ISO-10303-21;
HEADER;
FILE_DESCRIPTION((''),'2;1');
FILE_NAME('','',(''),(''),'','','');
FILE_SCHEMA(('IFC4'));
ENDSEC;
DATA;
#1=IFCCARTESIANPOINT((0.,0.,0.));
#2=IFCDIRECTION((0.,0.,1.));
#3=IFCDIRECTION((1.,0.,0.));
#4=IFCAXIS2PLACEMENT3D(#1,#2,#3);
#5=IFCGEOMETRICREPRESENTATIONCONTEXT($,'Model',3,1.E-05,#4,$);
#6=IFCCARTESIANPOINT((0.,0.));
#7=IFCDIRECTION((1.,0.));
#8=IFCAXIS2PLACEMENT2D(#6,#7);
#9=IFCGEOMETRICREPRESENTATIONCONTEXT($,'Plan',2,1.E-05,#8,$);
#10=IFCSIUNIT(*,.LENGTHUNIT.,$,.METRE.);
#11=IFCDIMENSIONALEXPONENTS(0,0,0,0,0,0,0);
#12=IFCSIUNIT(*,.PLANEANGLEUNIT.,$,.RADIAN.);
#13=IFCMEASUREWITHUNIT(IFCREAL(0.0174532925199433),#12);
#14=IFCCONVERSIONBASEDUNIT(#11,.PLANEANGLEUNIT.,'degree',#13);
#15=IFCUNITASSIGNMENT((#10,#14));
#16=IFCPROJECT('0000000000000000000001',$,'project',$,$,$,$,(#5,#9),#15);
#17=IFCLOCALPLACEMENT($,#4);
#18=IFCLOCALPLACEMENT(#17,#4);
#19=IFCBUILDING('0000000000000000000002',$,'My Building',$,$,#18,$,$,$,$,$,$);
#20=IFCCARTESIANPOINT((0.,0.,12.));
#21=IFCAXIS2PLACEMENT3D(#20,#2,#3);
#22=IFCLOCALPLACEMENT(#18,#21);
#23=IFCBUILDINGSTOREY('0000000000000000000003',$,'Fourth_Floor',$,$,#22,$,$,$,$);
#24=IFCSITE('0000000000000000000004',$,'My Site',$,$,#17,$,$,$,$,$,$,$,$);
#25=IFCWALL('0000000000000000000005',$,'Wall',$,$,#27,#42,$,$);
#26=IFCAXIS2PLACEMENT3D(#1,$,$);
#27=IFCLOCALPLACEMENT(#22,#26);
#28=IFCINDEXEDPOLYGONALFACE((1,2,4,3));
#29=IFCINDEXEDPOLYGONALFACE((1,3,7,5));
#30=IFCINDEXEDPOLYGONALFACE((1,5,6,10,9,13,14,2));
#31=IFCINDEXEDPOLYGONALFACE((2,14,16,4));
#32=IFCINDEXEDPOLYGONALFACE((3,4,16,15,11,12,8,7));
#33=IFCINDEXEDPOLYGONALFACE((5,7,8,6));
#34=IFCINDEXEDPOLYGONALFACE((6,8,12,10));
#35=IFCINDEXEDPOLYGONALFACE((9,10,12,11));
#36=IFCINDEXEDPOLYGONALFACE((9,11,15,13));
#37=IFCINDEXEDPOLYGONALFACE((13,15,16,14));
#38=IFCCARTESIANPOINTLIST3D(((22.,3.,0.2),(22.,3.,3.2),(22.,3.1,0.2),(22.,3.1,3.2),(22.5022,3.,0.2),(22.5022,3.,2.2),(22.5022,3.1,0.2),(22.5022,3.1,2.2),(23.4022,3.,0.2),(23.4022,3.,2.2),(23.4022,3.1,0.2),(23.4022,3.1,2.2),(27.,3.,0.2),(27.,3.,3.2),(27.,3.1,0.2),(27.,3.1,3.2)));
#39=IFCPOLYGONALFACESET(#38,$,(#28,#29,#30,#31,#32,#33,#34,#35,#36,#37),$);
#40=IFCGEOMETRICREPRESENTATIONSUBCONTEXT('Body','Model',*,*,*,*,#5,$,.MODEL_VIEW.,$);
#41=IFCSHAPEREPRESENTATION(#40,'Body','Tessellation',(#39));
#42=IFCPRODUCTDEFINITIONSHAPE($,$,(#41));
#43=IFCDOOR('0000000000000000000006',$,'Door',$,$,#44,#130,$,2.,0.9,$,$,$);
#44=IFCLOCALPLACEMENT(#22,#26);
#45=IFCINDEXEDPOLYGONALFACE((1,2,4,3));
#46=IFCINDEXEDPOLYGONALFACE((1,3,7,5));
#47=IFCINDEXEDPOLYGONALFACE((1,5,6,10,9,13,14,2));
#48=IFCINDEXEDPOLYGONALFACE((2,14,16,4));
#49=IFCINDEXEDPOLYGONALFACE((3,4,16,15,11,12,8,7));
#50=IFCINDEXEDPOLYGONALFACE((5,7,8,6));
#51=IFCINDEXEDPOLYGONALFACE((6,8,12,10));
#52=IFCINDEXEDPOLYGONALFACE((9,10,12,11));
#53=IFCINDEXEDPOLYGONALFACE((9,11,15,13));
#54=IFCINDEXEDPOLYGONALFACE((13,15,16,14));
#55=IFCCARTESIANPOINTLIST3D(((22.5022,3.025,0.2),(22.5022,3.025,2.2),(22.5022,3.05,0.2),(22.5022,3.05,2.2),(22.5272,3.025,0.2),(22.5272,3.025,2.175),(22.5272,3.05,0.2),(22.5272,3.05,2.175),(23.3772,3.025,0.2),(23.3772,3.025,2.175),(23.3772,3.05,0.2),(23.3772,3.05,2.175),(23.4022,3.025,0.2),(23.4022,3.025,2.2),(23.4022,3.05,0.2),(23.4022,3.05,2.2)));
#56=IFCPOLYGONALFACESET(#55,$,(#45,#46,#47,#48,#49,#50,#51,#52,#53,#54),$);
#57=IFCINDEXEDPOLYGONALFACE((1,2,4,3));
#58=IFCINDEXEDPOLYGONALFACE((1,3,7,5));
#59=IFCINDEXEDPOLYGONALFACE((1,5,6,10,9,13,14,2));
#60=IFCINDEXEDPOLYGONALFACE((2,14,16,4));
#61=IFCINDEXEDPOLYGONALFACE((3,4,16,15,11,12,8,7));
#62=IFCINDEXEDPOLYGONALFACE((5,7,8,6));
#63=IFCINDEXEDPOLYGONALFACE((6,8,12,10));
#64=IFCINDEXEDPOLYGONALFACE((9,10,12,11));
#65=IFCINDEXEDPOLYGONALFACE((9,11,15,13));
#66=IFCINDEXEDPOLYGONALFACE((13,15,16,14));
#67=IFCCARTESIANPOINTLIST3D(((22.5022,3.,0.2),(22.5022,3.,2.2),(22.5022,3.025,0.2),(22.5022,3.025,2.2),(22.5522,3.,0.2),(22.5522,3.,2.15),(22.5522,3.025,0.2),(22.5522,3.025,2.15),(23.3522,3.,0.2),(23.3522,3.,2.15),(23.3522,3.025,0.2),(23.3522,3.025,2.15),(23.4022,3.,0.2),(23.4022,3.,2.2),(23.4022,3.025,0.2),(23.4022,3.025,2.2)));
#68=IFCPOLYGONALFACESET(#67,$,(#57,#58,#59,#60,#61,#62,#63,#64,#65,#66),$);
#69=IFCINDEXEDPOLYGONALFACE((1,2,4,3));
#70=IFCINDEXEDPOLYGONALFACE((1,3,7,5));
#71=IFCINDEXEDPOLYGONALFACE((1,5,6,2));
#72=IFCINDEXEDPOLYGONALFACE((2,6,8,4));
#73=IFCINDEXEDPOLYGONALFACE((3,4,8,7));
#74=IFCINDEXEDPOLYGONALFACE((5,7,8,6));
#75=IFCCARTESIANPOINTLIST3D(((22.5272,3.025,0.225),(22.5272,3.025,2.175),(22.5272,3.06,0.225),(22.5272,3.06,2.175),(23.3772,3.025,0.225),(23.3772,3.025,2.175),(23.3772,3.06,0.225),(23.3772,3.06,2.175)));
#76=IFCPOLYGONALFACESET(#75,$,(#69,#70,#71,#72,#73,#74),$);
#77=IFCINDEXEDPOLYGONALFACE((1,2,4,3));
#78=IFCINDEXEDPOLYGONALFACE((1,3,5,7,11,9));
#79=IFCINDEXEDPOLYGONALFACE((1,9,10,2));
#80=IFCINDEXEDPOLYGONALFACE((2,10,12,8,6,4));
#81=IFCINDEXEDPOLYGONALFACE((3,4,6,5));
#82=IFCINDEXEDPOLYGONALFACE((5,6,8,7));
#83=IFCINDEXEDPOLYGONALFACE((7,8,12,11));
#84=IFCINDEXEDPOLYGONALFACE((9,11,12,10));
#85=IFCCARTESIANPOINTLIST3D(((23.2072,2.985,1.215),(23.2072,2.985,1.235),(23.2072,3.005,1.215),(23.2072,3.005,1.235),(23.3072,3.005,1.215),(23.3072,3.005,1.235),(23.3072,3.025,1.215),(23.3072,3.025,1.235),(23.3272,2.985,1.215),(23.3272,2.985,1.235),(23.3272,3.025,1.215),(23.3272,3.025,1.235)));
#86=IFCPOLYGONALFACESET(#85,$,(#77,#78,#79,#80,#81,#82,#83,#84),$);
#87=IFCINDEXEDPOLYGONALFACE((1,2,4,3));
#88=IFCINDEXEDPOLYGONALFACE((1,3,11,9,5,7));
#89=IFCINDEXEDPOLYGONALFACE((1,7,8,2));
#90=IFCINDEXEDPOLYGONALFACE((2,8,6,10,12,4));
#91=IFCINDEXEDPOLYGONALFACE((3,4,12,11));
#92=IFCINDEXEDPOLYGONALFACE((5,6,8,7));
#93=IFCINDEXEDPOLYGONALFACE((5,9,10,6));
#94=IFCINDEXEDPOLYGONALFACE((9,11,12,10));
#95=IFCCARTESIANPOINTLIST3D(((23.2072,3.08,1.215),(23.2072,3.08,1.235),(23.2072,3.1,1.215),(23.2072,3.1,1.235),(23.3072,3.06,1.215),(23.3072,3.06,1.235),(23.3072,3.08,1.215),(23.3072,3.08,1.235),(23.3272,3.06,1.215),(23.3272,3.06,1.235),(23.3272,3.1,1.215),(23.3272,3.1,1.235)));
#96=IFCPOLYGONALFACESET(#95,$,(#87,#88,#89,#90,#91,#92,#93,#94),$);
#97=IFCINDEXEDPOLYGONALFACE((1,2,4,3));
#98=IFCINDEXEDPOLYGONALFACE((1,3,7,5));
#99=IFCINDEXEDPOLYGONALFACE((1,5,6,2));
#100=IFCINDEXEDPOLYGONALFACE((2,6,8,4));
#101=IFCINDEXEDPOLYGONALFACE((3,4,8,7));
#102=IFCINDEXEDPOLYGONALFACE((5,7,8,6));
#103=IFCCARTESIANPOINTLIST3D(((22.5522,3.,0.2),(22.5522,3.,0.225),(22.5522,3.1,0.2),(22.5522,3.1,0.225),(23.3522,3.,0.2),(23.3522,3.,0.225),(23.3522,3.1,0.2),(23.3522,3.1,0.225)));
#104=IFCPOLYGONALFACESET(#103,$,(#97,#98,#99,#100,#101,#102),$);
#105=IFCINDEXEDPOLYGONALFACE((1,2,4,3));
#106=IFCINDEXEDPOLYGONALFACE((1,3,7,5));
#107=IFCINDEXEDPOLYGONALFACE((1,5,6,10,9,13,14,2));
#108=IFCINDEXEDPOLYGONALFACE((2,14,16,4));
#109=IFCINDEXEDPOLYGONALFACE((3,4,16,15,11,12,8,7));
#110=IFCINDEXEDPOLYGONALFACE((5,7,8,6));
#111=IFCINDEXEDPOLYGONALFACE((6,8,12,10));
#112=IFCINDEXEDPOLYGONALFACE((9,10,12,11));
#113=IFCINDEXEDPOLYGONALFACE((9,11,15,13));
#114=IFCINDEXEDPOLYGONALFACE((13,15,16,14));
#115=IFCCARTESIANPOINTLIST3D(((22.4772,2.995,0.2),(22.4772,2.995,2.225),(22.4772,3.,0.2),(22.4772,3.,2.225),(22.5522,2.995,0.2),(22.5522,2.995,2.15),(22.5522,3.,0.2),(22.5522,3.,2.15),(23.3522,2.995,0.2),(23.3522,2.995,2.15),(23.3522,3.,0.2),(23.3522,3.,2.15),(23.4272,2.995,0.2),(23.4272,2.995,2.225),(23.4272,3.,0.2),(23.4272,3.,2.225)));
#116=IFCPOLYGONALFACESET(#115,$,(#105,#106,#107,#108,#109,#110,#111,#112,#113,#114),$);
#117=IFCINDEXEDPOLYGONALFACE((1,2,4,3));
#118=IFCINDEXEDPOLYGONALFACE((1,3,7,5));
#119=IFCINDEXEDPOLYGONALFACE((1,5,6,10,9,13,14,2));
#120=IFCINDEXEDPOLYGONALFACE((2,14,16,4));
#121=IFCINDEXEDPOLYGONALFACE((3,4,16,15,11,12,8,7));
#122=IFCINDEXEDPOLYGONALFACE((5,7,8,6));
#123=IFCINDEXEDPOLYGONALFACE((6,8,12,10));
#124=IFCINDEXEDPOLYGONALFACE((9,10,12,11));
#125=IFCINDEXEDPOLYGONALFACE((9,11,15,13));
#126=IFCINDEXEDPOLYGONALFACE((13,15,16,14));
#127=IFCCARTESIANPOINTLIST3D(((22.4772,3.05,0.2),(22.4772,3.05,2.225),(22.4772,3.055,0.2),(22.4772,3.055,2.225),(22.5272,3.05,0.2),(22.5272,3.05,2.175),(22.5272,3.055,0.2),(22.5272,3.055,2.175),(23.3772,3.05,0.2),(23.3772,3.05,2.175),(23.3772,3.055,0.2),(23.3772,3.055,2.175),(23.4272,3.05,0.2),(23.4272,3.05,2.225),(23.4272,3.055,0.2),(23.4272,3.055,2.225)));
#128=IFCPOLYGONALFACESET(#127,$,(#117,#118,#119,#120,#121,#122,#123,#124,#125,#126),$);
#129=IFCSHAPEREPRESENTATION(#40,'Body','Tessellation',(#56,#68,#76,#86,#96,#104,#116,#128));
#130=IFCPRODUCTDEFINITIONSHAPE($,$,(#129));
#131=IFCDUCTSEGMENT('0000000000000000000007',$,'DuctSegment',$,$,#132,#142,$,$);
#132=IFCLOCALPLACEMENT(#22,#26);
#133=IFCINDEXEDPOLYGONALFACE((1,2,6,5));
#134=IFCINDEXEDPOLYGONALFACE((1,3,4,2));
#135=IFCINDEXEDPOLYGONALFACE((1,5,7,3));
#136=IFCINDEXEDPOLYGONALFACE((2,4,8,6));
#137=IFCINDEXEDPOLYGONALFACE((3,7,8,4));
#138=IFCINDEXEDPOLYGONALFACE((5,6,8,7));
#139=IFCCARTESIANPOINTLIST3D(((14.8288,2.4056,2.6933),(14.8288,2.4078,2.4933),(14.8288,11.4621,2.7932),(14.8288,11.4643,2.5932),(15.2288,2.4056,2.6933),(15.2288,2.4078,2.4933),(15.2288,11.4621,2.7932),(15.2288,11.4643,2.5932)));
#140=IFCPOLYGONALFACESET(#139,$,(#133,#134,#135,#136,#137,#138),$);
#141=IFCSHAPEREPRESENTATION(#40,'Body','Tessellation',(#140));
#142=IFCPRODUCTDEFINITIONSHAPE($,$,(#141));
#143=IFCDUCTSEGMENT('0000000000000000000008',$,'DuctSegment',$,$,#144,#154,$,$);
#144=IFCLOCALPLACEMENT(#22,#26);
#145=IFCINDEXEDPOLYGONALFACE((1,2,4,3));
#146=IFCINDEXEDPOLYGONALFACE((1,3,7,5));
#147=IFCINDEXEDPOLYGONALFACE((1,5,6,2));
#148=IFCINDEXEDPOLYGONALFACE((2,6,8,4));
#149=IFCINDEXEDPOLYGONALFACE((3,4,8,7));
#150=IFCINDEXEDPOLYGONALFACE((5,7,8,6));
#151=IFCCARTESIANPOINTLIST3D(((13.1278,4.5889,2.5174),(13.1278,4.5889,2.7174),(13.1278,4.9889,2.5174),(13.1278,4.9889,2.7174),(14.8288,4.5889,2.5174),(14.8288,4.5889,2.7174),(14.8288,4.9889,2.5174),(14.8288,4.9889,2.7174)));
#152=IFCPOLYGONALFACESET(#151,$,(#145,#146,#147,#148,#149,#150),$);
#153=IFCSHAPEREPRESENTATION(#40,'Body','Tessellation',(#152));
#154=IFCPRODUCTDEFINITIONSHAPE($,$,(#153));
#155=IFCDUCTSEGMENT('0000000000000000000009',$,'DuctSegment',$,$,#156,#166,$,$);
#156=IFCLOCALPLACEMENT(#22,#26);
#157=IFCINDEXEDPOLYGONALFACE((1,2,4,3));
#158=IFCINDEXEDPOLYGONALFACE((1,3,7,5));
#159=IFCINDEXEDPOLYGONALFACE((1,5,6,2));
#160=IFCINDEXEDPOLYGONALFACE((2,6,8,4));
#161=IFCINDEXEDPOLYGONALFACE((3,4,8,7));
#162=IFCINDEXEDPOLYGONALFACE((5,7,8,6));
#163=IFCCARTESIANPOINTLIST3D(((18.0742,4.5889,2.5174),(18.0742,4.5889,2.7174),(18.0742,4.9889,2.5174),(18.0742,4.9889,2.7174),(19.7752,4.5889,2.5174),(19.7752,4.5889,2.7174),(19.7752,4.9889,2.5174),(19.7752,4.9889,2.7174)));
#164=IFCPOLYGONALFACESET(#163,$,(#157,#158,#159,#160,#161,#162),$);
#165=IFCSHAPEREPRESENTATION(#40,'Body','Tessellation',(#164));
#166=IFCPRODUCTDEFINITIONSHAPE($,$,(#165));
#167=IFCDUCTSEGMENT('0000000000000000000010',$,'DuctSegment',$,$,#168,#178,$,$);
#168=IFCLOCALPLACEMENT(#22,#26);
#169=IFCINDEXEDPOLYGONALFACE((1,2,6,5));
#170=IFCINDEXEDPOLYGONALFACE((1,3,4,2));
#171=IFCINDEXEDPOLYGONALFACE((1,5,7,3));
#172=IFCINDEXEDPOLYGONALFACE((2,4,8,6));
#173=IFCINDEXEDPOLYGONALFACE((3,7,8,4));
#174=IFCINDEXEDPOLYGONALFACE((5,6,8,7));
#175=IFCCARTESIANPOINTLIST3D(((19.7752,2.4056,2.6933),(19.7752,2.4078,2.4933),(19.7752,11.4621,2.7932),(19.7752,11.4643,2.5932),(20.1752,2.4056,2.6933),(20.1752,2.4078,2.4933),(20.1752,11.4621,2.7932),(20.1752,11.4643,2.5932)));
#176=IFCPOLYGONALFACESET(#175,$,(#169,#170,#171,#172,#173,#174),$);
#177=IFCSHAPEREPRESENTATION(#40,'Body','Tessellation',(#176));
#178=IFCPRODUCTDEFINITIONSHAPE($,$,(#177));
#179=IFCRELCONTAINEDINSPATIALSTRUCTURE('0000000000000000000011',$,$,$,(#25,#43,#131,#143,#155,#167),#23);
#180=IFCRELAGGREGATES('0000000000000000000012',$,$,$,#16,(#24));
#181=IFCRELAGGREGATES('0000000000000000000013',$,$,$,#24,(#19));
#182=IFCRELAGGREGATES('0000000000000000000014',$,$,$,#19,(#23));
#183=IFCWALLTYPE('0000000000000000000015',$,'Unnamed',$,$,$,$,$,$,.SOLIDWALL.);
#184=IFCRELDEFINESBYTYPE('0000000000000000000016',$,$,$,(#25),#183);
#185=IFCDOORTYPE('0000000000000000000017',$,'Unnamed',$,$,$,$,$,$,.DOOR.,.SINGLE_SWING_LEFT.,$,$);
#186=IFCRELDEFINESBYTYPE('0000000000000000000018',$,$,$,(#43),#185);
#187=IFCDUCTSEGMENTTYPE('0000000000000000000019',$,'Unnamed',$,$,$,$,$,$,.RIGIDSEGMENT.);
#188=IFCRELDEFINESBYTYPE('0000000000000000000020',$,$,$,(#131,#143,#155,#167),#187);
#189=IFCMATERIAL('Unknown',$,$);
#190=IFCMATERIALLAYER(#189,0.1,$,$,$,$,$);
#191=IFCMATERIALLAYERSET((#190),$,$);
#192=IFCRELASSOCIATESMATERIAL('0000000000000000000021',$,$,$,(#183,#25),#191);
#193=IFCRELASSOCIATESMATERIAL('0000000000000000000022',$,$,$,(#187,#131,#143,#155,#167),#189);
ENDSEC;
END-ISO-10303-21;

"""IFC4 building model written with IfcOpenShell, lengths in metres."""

from ifc_helpers import new_model, entity, si_unit, converted_unit, frame, origin_with_axes, origin_2d_with_axis, place, context, subcontext, project, spatial, line, indexed_curve, rectangle, outline, extrude, shape, source, transform, mapped, material, layer, layer_set, layer_usage, material_profile, profile_set, profile_usage, type_object, type_shapes, element, fill, save


model = new_model("IFC4")

# Units and contexts
model_context = context("Model", 3, precision=1e-05, world=origin_with_axes())
plan_context = context("Plan", 2, precision=1e-05, world=origin_2d_with_axis())
body_context_1 = subcontext(model_context, "Body", "Model", "MODEL_VIEW")
body_context_2 = subcontext(plan_context, "Body", "Plan", "PLAN_VIEW")
ifc_project = project(units=[si_unit("LENGTHUNIT", "METRE"), converted_unit("PLANEANGLEUNIT", "degree", entity("IfcReal", 0.0174532925199433), si_unit("PLANEANGLEUNIT", "RADIAN"), dimensions=[0, 0, 0, 0, 0, 0, 0])], contexts=[model_context, plan_context])

# Site, building, storey
site_placement = place(None, origin_with_axes())
site = spatial("IfcSite", under=ifc_project, at=site_placement, Name="My Site")
building_placement = place(site_placement, origin_with_axes())
building = spatial("IfcBuilding", under=site, at=building_placement, Name="My Building")
storey_placement = place(building_placement, frame((0.0, 0.0, 12.0), z_axis=(0.0, 0.0, 1.0), x_axis=(1.0, 0.0, 0.0)))
storey = spatial("IfcBuildingStorey", under=building, at=storey_placement, Name="Fourth_Floor")

# Wall, opening, door
ifc_material = material(Name="Unknown")
ifc_layer = layer(ifc_material, 0.1)
ifc_layer_set = layer_set([ifc_layer])
wall_type = type_object("IfcWallType", Name="Unnamed", PredefinedType="SOLIDWALL", material=ifc_layer_set)
shared_shape_1 = source(origin_with_axes(), body_context_1, "Body", "SweptSolid", [
    extrude(outline(indexed_curve([(0.0, 0.0), (0.9, 0.0), (0.9, 2.0), (0.0, 2.0)], segments=[line(1, 2, 3, 4, 1)])), frame((0.0, -0.6, 0.0), z_axis=(0.0, -1.0, 0.0), x_axis=(1.0, 0.0, 0.0)), (0.0, 0.0, -1.0), 1.2),
])
door_type = type_object("IfcDoorType", Name="Unnamed", OperationType="SINGLE_SWING_LEFT", PredefinedType="DOOR")
shared_shape_2 = source(origin_with_axes(), body_context_1, "Body", "SweptSolid", [
    extrude(outline(indexed_curve([(0.0, 0.0), (0.0, 2.0), (0.9, 2.0), (0.9, 0.0), (0.875, 0.0), (0.875, 1.975), (0.025, 1.975), (0.025, 0.0)], segments=[line(1, 2, 3, 4, 5, 6, 7, 8, 1)])), frame((0.0, 0.025, 0.0), z_axis=(0.0, -1.0, 0.0), x_axis=(1.0, 0.0, 0.0)), (0.0, 0.0, -1.0), 0.025),
    extrude(outline(indexed_curve([(0.0, 0.0), (0.0, 2.0), (0.9, 2.0), (0.9, 0.0), (0.85, 0.0), (0.85, 1.95), (0.05, 1.95), (0.05, 0.0)], segments=[line(1, 2, 3, 4, 5, 6, 7, 8, 1)])), frame((0.0, 0.0, 0.0), z_axis=(0.0, -1.0, 0.0), x_axis=(1.0, 0.0, 0.0)), (0.0, 0.0, -1.0), 0.025),
    extrude(outline(indexed_curve([(0.0, 0.0), (0.85, 0.0), (0.85, 0.035), (0.0, 0.035)], segments=[line(1, 2, 3, 4, 1)])), frame((0.025, 0.025, 0.025), z_axis=(0.0, 0.0, 1.0), x_axis=(1.0, 0.0, 0.0)), (0.0, 0.0, 1.0), 1.95),
    extrude(outline(indexed_curve([(0.0, 0.0), (0.0, -0.04), (-0.12, -0.04), (-0.12, -0.02), (-0.02, -0.02), (-0.02, 0.0)], segments=[line(1, 2, 3, 4, 5, 6, 1)])), frame((0.825, 0.025, 1.015), z_axis=(0.0, 0.0, 1.0), x_axis=(1.0, 0.0, 0.0)), (0.0, 0.0, 1.0), 0.02),
    extrude(outline(indexed_curve([(0.0, 0.0), (0.0, 0.04), (-0.12, 0.04), (-0.12, 0.02), (-0.02, 0.02), (-0.02, 0.0)], segments=[line(1, 2, 3, 4, 5, 6, 1)])), frame((0.825, 0.06, 1.015), z_axis=(0.0, 0.0, 1.0), x_axis=(1.0, 0.0, 0.0)), (0.0, 0.0, 1.0), 0.02),
    extrude(outline(indexed_curve([(0.0, 0.0), (0.8, 0.0), (0.8, 0.1), (0.0, 0.1)], segments=[line(1, 2, 3, 4, 1)])), frame((0.05, 0.0, 0.0), z_axis=(0.0, 0.0, 1.0), x_axis=(1.0, 0.0, 0.0)), (0.0, 0.0, 1.0), 0.025),
    extrude(outline(indexed_curve([(0.0, 0.0), (0.0, 2.025), (0.95, 2.025), (0.95, 0.0), (0.875, 0.0), (0.875, 1.95), (0.075, 1.95), (0.075, 0.0)], segments=[line(1, 2, 3, 4, 5, 6, 7, 8, 1)])), frame((-0.025, -0.005, 0.0), z_axis=(0.0, -1.0, 0.0), x_axis=(1.0, 0.0, 0.0)), (0.0, 0.0, -1.0), 0.005),
    extrude(outline(indexed_curve([(0.0, 0.0), (0.0, 2.025), (0.95, 2.025), (0.95, 0.0), (0.9, 0.0), (0.9, 1.975), (0.05, 1.975), (0.05, 0.0)], segments=[line(1, 2, 3, 4, 5, 6, 7, 8, 1)])), frame((-0.025, 0.05, 0.0), z_axis=(0.0, -1.0, 0.0), x_axis=(1.0, 0.0, 0.0)), (0.0, 0.0, -1.0), 0.005),
])
shared_shape_3 = source(origin_with_axes(), body_context_2, "Body", "Curve2D", [
    entity("IfcIndexedPolyCurve", entity("IfcCartesianPointList2D", [[0.0, 0.0], [0.0, 0.05], [0.025, 0.05], [0.025, 0.025], [0.05, 0.025], [0.05, 0.0]]), [entity("IfcLineIndex", [1, 2, 3, 4, 5, 6, 1])]),
    entity("IfcIndexedPolyCurve", entity("IfcCartesianPointList2D", [[0.9, 0.0], [0.9, 0.05], [0.875, 0.05], [0.875, 0.025], [0.85, 0.025], [0.85, 0.0]]), [entity("IfcLineIndex", [1, 2, 3, 4, 5, 6, 1])]),
    entity("IfcTrimmedCurve", entity("IfcEllipse", entity("IfcAxis2Placement2D", entity("IfcCartesianPoint", [0.06, 0.05]), entity("IfcDirection", [1.0, 0.0])), 0.815, 0.85), [entity("IfcCartesianPoint", [0.875, 0.05])], [entity("IfcCartesianPoint", [0.06, 0.9])], True, "CARTESIAN"),
    entity("IfcIndexedPolyCurve", entity("IfcCartesianPointList2D", [[0.025, 0.05], [0.06, 0.05], [0.06, 0.9], [0.025, 0.9]]), [entity("IfcLineIndex", [1, 2, 3, 4, 1])]),
])
type_shapes(door_type, [shared_shape_2, shared_shape_3])
ifc_layer_usage_1 = layer_usage(ifc_layer_set, "AXIS2", "POSITIVE", 0.0)
wall_1_placement = place(storey_placement, frame((22.0, 3.0, 0.2), z_axis=(0.0, 0.0, 1.0), x_axis=(1.0, 0.0, 0.0)))
wall_1 = element("IfcWall", 1, at=wall_1_placement, inside=storey, type_object=wall_type, material=ifc_layer_usage_1, Name="Wall", context=body_context_1, shape_type="SweptSolid", body=[
    extrude(outline(indexed_curve([(0.0, 0.0), (0.0, 0.1), (5.0, 0.1), (5.0, 0.0)], segments=[line(1, 2, 3, 4, 1)])), origin_with_axes(), (0.0, 0.0, 1.0), 3.0),
])
opening_1_placement = place(wall_1_placement, frame((0.5022, 0.0, 0.0), z_axis=(0.0, 0.0, 1.0), x_axis=(1.0, 0.0, 0.0)))
opening_1 = element("IfcOpeningElement", 2, at=opening_1_placement, cuts=wall_1, PredefinedType="OPENING", context=body_context_1, shape_type="MappedRepresentation", body=[
    mapped(shared_shape_1, transform((0.0, 0.0, 0.0), x_axis=(1.0, 0.0, 0.0), y_axis=(0.0, 1.0, 0.0), z_axis=(0.0, 0.0, 1.0), scale=1.0)),
])
door_1_placement = place(opening_1_placement, origin_with_axes())
door_1 = element("IfcDoor", 3, at=door_1_placement, inside=storey, type_object=door_type, Name="Door", OverallHeight=2.0, OverallWidth=0.9, shapes=[
    shape(body_context_1, "Body", "MappedRepresentation", [mapped(shared_shape_2, transform((0.0, 0.0, 0.0), x_axis=(1.0, 0.0, 0.0), y_axis=(0.0, 1.0, 0.0), z_axis=(0.0, 0.0, 1.0), scale=1.0))]),
    shape(body_context_2, "Body", "MappedRepresentation", [mapped(shared_shape_3, transform((0.0, 0.0, 0.0), x_axis=(1.0, 0.0, 0.0), y_axis=(0.0, 1.0, 0.0), z_axis=(0.0, 0.0, 1.0), scale=1.0))]),
])
fill(opening_1, door_1)

# Duct segments
ifc_material_profile_1 = material_profile(ifc_material, rectangle(XDim=0.4, YDim=0.2))
ifc_profile_set_1 = profile_set([ifc_material_profile_1])
ifc_profile_usage_1 = profile_usage(ifc_profile_set_1, cardinal=5)
duct_segment_type = type_object("IfcDuctSegmentType", Name="Unnamed", PredefinedType="RIGIDSEGMENT", material=ifc_profile_set_1)
duct_segment_1_placement = place(storey_placement, frame((15.0288, 2.4067, 2.5933), z_axis=(0.0, 0.999939, 0.011037), x_axis=(-1.0, 0.0, 0.0)))
element("IfcDuctSegment", 4, at=duct_segment_1_placement, inside=storey, type_object=duct_segment_type, material=ifc_profile_usage_1, Name="DuctSegment", context=body_context_1, shape_type="SweptSolid", body=[
    extrude(rectangle(XDim=0.4, YDim=0.2), origin_with_axes(), (0.0, 0.0, 1.0), 9.057),
])
ifc_profile_usage_2 = profile_usage(ifc_profile_set_1, cardinal=5)
duct_segment_2_placement = place(storey_placement, frame((14.8288, 4.7889, 2.6174), z_axis=(-1.0, 0.000001, 0.000001), x_axis=(-0.000001, -1.0, 0.0)))
element("IfcDuctSegment", 5, at=duct_segment_2_placement, inside=storey, type_object=duct_segment_type, material=ifc_profile_usage_2, Name="DuctSegment", context=body_context_1, shape_type="SweptSolid", body=[
    extrude(rectangle(XDim=0.4, YDim=0.2), origin_with_axes(), (0.0, 0.0, 1.0), 1.701),
])
ifc_profile_usage_3 = profile_usage(ifc_profile_set_1, cardinal=5)
duct_segment_3_placement = place(storey_placement, frame((19.7752, 4.7889, 2.6174), z_axis=(-1.0, 0.000001, 0.000001), x_axis=(-0.000001, -1.0, 0.0)))
element("IfcDuctSegment", 6, at=duct_segment_3_placement, inside=storey, type_object=duct_segment_type, material=ifc_profile_usage_3, Name="DuctSegment", context=body_context_1, shape_type="SweptSolid", body=[
    extrude(rectangle(XDim=0.4, YDim=0.2), origin_with_axes(), (0.0, 0.0, 1.0), 1.701),
])
ifc_profile_usage_4 = profile_usage(ifc_profile_set_1, cardinal=5)
duct_segment_4_placement = place(storey_placement, frame((19.9752, 2.4067, 2.5933), z_axis=(0.0, 0.999939, 0.011037), x_axis=(-1.0, 0.0, 0.0)))
element("IfcDuctSegment", 7, at=duct_segment_4_placement, inside=storey, type_object=duct_segment_type, material=ifc_profile_usage_4, Name="DuctSegment", context=body_context_1, shape_type="SweptSolid", body=[
    extrude(rectangle(XDim=0.4, YDim=0.2), origin_with_axes(), (0.0, 0.0, 1.0), 9.057),
])

save(model, "model.ifc")
